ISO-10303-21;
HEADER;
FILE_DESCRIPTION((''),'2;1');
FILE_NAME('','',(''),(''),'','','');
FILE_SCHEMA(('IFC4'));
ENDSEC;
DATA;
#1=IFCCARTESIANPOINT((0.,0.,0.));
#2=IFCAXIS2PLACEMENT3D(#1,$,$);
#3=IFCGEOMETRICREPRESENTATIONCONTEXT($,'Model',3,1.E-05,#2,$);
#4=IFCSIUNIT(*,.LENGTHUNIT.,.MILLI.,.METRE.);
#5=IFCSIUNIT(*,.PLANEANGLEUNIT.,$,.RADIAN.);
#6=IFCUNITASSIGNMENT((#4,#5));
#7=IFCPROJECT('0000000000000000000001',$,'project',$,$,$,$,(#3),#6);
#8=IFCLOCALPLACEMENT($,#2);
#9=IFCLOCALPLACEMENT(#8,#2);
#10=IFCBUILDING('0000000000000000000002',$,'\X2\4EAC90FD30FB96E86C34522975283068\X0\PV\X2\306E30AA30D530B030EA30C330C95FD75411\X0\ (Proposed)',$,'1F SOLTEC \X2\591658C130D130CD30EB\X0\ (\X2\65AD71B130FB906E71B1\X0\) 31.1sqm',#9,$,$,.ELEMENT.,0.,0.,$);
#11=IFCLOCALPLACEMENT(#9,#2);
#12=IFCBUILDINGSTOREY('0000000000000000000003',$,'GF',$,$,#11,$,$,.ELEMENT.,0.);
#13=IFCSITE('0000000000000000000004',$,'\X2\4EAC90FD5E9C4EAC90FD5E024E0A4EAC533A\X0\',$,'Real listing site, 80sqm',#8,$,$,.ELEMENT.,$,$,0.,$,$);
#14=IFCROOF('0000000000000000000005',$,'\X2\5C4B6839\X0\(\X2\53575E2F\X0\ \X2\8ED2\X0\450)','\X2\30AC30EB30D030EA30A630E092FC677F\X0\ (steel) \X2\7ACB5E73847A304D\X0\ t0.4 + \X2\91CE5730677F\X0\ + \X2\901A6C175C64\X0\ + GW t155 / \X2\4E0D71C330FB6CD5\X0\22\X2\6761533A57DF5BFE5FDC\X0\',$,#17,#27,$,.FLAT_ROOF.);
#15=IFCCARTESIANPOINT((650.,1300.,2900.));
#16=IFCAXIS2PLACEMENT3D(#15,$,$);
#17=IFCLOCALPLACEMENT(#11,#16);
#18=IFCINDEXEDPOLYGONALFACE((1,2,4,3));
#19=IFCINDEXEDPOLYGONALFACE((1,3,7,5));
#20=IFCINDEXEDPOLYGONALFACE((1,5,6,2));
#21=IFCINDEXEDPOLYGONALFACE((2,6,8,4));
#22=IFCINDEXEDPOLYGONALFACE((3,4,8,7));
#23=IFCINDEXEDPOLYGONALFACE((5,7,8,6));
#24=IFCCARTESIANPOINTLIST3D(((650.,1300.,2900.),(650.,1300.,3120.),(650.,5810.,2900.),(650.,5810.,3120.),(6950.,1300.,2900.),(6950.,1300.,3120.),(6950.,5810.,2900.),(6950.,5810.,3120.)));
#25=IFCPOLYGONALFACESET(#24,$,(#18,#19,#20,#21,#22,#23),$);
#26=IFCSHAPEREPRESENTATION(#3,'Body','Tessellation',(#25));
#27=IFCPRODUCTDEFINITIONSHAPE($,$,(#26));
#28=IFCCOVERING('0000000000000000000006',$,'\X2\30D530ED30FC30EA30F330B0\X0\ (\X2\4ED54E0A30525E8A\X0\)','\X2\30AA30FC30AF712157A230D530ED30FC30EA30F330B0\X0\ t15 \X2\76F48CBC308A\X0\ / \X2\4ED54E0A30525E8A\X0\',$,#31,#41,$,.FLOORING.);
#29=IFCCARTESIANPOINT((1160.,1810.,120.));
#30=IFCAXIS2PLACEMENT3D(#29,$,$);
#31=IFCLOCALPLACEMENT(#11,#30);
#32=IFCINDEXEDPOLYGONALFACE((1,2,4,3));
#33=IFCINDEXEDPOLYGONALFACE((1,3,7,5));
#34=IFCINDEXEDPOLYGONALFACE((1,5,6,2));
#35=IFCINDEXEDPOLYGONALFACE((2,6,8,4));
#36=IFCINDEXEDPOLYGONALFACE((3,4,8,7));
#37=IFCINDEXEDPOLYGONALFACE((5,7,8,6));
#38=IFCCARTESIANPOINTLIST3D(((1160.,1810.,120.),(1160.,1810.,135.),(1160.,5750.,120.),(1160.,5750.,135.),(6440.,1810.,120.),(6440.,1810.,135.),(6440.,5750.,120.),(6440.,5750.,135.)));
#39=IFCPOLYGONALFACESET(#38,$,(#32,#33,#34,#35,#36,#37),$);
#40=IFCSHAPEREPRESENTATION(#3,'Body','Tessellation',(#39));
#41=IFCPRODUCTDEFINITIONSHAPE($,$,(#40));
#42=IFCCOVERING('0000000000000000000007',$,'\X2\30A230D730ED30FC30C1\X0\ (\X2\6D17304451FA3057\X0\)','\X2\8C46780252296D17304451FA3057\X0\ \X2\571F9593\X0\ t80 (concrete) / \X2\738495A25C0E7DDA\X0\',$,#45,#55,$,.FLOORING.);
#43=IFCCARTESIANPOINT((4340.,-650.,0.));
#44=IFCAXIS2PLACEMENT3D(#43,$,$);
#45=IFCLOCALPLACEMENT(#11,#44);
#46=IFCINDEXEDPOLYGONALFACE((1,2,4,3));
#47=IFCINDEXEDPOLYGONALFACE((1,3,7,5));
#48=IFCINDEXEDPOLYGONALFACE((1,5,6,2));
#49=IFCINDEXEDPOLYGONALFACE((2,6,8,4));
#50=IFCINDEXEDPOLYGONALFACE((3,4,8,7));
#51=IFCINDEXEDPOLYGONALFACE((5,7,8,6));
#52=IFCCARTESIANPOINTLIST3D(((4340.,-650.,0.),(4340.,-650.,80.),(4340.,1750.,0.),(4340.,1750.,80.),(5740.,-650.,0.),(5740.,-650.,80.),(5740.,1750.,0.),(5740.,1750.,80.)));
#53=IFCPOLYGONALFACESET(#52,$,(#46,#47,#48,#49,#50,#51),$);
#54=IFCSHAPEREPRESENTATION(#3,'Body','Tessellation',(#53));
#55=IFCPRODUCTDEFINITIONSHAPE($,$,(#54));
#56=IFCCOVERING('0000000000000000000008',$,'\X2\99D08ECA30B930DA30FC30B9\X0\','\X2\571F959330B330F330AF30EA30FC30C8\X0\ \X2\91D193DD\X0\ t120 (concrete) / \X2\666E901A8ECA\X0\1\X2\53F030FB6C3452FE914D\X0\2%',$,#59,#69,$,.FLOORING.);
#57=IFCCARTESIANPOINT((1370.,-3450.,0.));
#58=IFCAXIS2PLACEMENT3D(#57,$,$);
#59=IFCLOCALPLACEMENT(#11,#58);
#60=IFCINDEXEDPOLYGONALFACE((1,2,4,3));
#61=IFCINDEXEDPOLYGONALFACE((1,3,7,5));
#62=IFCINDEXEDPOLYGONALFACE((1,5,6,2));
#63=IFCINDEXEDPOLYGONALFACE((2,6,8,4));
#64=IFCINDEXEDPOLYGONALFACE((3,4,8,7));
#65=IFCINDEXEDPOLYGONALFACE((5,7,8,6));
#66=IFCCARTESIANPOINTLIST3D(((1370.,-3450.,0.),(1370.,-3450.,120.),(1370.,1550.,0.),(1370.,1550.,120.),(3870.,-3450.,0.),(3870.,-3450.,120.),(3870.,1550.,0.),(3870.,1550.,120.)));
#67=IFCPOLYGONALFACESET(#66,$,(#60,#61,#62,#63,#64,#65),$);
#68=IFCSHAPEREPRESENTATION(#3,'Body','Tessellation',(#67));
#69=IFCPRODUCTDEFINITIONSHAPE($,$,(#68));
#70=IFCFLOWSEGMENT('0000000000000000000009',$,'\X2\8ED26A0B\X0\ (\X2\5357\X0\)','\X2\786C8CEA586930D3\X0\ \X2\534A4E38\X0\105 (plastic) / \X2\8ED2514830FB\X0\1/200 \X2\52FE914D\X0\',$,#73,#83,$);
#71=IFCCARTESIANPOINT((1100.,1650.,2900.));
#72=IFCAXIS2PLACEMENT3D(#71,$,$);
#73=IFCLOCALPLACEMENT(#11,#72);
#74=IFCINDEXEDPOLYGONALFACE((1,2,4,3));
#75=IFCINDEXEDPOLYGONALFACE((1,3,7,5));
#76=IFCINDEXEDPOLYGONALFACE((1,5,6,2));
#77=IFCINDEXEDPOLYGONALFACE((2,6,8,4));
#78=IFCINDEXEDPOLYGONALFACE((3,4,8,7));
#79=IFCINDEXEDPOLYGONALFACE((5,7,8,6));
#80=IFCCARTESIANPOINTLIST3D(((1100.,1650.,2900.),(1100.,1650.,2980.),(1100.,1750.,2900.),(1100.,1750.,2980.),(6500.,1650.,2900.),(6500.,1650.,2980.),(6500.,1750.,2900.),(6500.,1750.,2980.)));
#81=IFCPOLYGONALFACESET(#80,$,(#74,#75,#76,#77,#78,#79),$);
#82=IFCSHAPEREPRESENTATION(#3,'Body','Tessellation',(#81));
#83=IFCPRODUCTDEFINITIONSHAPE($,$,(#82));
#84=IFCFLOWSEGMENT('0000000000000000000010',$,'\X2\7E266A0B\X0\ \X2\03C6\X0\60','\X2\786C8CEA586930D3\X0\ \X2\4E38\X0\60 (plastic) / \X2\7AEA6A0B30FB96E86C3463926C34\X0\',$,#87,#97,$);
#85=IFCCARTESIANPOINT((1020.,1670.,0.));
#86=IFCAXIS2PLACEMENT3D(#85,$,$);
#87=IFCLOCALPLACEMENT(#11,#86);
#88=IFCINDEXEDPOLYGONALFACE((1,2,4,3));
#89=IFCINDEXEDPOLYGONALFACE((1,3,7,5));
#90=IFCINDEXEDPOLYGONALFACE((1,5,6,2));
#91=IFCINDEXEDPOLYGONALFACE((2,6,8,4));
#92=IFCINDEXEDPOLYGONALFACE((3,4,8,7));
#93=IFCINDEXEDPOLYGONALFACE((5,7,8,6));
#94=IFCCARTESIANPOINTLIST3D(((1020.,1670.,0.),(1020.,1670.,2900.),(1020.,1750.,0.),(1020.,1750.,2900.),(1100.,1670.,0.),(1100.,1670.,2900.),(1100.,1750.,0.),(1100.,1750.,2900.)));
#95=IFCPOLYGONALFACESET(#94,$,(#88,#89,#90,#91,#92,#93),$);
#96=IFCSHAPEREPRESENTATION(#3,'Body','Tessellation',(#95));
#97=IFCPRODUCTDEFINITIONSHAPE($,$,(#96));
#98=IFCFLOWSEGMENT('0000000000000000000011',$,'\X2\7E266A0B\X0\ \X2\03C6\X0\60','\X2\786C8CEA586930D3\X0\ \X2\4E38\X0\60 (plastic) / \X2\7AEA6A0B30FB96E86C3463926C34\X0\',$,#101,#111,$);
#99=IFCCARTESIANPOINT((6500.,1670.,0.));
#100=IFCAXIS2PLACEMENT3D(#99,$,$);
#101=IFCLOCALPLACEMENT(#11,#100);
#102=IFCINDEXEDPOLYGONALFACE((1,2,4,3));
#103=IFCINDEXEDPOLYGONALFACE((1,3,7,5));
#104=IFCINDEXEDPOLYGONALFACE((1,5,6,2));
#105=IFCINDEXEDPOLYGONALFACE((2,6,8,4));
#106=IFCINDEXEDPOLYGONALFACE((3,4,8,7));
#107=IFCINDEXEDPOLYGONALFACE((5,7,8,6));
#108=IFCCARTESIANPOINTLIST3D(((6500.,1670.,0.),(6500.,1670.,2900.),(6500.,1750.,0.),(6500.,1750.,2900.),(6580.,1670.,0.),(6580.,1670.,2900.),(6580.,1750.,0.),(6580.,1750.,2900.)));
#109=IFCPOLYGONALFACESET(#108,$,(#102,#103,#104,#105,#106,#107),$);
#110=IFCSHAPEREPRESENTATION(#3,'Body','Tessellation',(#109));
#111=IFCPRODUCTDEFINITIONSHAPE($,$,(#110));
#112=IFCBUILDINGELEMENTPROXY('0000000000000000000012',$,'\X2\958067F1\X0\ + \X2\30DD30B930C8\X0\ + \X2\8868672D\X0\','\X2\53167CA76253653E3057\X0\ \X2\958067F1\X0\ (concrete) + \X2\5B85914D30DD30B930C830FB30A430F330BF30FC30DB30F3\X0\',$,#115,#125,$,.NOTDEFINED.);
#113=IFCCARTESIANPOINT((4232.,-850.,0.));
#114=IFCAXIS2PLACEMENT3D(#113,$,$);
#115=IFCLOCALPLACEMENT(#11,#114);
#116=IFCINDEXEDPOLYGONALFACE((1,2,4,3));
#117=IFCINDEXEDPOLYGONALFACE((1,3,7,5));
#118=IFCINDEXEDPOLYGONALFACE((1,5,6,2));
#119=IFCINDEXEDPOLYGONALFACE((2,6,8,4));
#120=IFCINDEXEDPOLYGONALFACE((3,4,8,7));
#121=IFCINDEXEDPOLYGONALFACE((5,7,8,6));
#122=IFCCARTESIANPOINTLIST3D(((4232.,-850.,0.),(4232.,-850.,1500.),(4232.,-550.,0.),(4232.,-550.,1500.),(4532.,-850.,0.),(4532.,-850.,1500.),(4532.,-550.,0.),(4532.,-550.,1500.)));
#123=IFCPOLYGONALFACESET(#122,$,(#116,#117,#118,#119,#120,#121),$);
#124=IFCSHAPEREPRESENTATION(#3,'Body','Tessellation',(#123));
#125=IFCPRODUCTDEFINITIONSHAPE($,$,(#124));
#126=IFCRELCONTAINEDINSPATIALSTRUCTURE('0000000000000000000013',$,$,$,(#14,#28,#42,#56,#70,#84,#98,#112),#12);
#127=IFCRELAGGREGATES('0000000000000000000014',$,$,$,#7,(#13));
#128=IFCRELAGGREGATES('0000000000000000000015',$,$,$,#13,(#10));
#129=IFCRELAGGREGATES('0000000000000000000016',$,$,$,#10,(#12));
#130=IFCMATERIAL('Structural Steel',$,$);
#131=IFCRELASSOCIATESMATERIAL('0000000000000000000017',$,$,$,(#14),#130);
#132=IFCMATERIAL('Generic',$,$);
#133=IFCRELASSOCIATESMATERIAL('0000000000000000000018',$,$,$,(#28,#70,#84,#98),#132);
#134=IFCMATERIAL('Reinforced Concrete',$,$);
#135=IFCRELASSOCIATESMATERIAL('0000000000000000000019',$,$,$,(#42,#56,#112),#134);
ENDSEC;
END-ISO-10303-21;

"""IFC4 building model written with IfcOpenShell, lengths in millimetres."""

from ifc_helpers import new_model, si_unit, frame, frame_2d, origin, place, context, project, spatial, rectangle, extrude, material, element, save


model = new_model("IFC4")

# Units and contexts
model_context = context("Model", 3, precision=1e-05, world=origin())
ifc_project = project(units=[si_unit("LENGTHUNIT", "METRE", prefix="MILLI"), si_unit("PLANEANGLEUNIT", "RADIAN")], contexts=[model_context])

# Site, building, storey
site_placement = place(None, origin())
site = spatial("IfcSite", under=ifc_project, at=site_placement, Name="京都府京都市上京区", ObjectType="Real listing site, 80sqm", CompositionType="ELEMENT", RefElevation=0.0)
building_placement = place(site_placement, origin())
building = spatial("IfcBuilding", under=site, at=building_placement, Name="京都・雨水利用とPVのオフグリッド志向 (Proposed)", ObjectType="1F SOLTEC 外壁パネル (断熱・遮熱) 31.1sqm", CompositionType="ELEMENT", ElevationOfRefHeight=0.0, ElevationOfTerrain=0.0)
storey_placement = place(building_placement, origin())
storey = spatial("IfcBuildingStorey", under=building, at=storey_placement, Name="GF", CompositionType="ELEMENT", Elevation=0.0)

# Shared definitions
ifc_material_1 = material(Name="Reinforced Concrete")

# Roof
ifc_material_2 = material(Name="Structural Steel")
roof_placement = place(storey_placement, frame((650.0, 1300.0, 2900.0)))
element("IfcRoof", 1, at=roof_placement, inside=storey, material=ifc_material_2, Name="屋根(南帯 軒450)", Description="ガルバリウム鋼板 (steel) 立平葺き t0.4 + 野地板 + 通気層 + GW t155 / 不燃・法22条区域対応", PredefinedType="FLAT_ROOF", context=model_context, shape_type="SweptSolid", body=[
    extrude(rectangle(XDim=6300.0, YDim=4510.0, at=frame_2d((3150.0, 2255.0))), frame((650.0, 1300.0, 2900.0)), (0.0, 0.0, 1.0), 220.0),
])

# Coverings
ifc_material_3 = material(Name="Generic")
covering_1_placement = place(storey_placement, frame((1160.0, 1810.0, 120.0)))
element("IfcCovering", 2, at=covering_1_placement, inside=storey, material=ifc_material_3, Name="フローリング (仕上げ床)", Description="オーク無垢フローリング t15 直貼り / 仕上げ床", PredefinedType="FLOORING", context=model_context, shape_type="SweptSolid", body=[
    extrude(rectangle(XDim=5280.0, YDim=3940.0, at=frame_2d((2640.0, 1970.0))), frame((1160.0, 1810.0, 120.0)), (0.0, 0.0, 1.0), 15.0),
])
covering_2_placement = place(storey_placement, frame((4340.0, -650.0, 0.0)))
element("IfcCovering", 3, at=covering_2_placement, inside=storey, material=ifc_material_1, Name="アプローチ (洗い出し)", Description="豆砂利洗い出し 土間 t80 (concrete) / 玄関導線", PredefinedType="FLOORING", context=model_context, shape_type="SweptSolid", body=[
    extrude(rectangle(XDim=1400.0, YDim=2400.0, at=frame_2d((700.0, 1200.0))), frame((4340.0, -650.0, 0.0)), (0.0, 0.0, 1.0), 80.0),
])
covering_3_placement = place(storey_placement, frame((1370.0, -3450.0, 0.0)))
element("IfcCovering", 4, at=covering_3_placement, inside=storey, material=ifc_material_1, Name="駐車スペース", Description="土間コンクリート 金鏝 t120 (concrete) / 普通車1台・水勾配2%", PredefinedType="FLOORING", context=model_context, shape_type="SweptSolid", body=[
    extrude(rectangle(XDim=2500.0, YDim=5000.0, at=frame_2d((1250.0, 2500.0))), frame((1370.0, -3450.0, 0.0)), (0.0, 0.0, 1.0), 120.0),
])

# Flow segments
flow_segment_1_placement = place(storey_placement, frame((1100.0, 1650.0, 2900.0)))
element("IfcFlowSegment", 5, at=flow_segment_1_placement, inside=storey, material=ifc_material_3, Name="軒樋 (南)", Description="硬質塩ビ 半丸105 (plastic) / 軒先・1/200 勾配", context=model_context, shape_type="SweptSolid", body=[
    extrude(rectangle(XDim=5400.0, YDim=100.0, at=frame_2d((2700.0, 50.0))), frame((1100.0, 1650.0, 2900.0)), (0.0, 0.0, 1.0), 80.0),
])
flow_segment_2_placement = place(storey_placement, frame((1020.0, 1670.0, 0.0)))
element("IfcFlowSegment", 6, at=flow_segment_2_placement, inside=storey, material=ifc_material_3, Name="縦樋 φ60", Description="硬質塩ビ 丸60 (plastic) / 竪樋・雨水排水", context=model_context, shape_type="SweptSolid", body=[
    extrude(rectangle(XDim=80.0, YDim=80.0, at=frame_2d((40.0, 40.0))), frame((1020.0, 1670.0, 0.0)), (0.0, 0.0, 1.0), 2900.0),
])
flow_segment_3_placement = place(storey_placement, frame((6500.0, 1670.0, 0.0)))
element("IfcFlowSegment", 7, at=flow_segment_3_placement, inside=storey, material=ifc_material_3, Name="縦樋 φ60", Description="硬質塩ビ 丸60 (plastic) / 竪樋・雨水排水", context=model_context, shape_type="SweptSolid", body=[
    extrude(rectangle(XDim=80.0, YDim=80.0, at=frame_2d((40.0, 40.0))), frame((6500.0, 1670.0, 0.0)), (0.0, 0.0, 1.0), 2900.0),
])

# Building element proxy
proxy_placement = place(storey_placement, frame((4232.0, -850.0, 0.0)))
element("IfcBuildingElementProxy", 8, at=proxy_placement, inside=storey, material=ifc_material_1, Name="門柱 + ポスト + 表札", Description="化粧打放し 門柱 (concrete) + 宅配ポスト・インターホン", PredefinedType="NOTDEFINED", context=model_context, shape_type="SweptSolid", body=[
    extrude(rectangle(XDim=300.0, YDim=300.0, at=frame_2d((150.0, 150.0))), frame((4232.0, -850.0, 0.0)), (0.0, 0.0, 1.0), 1500.0),
])

save(model, "model.ifc")
